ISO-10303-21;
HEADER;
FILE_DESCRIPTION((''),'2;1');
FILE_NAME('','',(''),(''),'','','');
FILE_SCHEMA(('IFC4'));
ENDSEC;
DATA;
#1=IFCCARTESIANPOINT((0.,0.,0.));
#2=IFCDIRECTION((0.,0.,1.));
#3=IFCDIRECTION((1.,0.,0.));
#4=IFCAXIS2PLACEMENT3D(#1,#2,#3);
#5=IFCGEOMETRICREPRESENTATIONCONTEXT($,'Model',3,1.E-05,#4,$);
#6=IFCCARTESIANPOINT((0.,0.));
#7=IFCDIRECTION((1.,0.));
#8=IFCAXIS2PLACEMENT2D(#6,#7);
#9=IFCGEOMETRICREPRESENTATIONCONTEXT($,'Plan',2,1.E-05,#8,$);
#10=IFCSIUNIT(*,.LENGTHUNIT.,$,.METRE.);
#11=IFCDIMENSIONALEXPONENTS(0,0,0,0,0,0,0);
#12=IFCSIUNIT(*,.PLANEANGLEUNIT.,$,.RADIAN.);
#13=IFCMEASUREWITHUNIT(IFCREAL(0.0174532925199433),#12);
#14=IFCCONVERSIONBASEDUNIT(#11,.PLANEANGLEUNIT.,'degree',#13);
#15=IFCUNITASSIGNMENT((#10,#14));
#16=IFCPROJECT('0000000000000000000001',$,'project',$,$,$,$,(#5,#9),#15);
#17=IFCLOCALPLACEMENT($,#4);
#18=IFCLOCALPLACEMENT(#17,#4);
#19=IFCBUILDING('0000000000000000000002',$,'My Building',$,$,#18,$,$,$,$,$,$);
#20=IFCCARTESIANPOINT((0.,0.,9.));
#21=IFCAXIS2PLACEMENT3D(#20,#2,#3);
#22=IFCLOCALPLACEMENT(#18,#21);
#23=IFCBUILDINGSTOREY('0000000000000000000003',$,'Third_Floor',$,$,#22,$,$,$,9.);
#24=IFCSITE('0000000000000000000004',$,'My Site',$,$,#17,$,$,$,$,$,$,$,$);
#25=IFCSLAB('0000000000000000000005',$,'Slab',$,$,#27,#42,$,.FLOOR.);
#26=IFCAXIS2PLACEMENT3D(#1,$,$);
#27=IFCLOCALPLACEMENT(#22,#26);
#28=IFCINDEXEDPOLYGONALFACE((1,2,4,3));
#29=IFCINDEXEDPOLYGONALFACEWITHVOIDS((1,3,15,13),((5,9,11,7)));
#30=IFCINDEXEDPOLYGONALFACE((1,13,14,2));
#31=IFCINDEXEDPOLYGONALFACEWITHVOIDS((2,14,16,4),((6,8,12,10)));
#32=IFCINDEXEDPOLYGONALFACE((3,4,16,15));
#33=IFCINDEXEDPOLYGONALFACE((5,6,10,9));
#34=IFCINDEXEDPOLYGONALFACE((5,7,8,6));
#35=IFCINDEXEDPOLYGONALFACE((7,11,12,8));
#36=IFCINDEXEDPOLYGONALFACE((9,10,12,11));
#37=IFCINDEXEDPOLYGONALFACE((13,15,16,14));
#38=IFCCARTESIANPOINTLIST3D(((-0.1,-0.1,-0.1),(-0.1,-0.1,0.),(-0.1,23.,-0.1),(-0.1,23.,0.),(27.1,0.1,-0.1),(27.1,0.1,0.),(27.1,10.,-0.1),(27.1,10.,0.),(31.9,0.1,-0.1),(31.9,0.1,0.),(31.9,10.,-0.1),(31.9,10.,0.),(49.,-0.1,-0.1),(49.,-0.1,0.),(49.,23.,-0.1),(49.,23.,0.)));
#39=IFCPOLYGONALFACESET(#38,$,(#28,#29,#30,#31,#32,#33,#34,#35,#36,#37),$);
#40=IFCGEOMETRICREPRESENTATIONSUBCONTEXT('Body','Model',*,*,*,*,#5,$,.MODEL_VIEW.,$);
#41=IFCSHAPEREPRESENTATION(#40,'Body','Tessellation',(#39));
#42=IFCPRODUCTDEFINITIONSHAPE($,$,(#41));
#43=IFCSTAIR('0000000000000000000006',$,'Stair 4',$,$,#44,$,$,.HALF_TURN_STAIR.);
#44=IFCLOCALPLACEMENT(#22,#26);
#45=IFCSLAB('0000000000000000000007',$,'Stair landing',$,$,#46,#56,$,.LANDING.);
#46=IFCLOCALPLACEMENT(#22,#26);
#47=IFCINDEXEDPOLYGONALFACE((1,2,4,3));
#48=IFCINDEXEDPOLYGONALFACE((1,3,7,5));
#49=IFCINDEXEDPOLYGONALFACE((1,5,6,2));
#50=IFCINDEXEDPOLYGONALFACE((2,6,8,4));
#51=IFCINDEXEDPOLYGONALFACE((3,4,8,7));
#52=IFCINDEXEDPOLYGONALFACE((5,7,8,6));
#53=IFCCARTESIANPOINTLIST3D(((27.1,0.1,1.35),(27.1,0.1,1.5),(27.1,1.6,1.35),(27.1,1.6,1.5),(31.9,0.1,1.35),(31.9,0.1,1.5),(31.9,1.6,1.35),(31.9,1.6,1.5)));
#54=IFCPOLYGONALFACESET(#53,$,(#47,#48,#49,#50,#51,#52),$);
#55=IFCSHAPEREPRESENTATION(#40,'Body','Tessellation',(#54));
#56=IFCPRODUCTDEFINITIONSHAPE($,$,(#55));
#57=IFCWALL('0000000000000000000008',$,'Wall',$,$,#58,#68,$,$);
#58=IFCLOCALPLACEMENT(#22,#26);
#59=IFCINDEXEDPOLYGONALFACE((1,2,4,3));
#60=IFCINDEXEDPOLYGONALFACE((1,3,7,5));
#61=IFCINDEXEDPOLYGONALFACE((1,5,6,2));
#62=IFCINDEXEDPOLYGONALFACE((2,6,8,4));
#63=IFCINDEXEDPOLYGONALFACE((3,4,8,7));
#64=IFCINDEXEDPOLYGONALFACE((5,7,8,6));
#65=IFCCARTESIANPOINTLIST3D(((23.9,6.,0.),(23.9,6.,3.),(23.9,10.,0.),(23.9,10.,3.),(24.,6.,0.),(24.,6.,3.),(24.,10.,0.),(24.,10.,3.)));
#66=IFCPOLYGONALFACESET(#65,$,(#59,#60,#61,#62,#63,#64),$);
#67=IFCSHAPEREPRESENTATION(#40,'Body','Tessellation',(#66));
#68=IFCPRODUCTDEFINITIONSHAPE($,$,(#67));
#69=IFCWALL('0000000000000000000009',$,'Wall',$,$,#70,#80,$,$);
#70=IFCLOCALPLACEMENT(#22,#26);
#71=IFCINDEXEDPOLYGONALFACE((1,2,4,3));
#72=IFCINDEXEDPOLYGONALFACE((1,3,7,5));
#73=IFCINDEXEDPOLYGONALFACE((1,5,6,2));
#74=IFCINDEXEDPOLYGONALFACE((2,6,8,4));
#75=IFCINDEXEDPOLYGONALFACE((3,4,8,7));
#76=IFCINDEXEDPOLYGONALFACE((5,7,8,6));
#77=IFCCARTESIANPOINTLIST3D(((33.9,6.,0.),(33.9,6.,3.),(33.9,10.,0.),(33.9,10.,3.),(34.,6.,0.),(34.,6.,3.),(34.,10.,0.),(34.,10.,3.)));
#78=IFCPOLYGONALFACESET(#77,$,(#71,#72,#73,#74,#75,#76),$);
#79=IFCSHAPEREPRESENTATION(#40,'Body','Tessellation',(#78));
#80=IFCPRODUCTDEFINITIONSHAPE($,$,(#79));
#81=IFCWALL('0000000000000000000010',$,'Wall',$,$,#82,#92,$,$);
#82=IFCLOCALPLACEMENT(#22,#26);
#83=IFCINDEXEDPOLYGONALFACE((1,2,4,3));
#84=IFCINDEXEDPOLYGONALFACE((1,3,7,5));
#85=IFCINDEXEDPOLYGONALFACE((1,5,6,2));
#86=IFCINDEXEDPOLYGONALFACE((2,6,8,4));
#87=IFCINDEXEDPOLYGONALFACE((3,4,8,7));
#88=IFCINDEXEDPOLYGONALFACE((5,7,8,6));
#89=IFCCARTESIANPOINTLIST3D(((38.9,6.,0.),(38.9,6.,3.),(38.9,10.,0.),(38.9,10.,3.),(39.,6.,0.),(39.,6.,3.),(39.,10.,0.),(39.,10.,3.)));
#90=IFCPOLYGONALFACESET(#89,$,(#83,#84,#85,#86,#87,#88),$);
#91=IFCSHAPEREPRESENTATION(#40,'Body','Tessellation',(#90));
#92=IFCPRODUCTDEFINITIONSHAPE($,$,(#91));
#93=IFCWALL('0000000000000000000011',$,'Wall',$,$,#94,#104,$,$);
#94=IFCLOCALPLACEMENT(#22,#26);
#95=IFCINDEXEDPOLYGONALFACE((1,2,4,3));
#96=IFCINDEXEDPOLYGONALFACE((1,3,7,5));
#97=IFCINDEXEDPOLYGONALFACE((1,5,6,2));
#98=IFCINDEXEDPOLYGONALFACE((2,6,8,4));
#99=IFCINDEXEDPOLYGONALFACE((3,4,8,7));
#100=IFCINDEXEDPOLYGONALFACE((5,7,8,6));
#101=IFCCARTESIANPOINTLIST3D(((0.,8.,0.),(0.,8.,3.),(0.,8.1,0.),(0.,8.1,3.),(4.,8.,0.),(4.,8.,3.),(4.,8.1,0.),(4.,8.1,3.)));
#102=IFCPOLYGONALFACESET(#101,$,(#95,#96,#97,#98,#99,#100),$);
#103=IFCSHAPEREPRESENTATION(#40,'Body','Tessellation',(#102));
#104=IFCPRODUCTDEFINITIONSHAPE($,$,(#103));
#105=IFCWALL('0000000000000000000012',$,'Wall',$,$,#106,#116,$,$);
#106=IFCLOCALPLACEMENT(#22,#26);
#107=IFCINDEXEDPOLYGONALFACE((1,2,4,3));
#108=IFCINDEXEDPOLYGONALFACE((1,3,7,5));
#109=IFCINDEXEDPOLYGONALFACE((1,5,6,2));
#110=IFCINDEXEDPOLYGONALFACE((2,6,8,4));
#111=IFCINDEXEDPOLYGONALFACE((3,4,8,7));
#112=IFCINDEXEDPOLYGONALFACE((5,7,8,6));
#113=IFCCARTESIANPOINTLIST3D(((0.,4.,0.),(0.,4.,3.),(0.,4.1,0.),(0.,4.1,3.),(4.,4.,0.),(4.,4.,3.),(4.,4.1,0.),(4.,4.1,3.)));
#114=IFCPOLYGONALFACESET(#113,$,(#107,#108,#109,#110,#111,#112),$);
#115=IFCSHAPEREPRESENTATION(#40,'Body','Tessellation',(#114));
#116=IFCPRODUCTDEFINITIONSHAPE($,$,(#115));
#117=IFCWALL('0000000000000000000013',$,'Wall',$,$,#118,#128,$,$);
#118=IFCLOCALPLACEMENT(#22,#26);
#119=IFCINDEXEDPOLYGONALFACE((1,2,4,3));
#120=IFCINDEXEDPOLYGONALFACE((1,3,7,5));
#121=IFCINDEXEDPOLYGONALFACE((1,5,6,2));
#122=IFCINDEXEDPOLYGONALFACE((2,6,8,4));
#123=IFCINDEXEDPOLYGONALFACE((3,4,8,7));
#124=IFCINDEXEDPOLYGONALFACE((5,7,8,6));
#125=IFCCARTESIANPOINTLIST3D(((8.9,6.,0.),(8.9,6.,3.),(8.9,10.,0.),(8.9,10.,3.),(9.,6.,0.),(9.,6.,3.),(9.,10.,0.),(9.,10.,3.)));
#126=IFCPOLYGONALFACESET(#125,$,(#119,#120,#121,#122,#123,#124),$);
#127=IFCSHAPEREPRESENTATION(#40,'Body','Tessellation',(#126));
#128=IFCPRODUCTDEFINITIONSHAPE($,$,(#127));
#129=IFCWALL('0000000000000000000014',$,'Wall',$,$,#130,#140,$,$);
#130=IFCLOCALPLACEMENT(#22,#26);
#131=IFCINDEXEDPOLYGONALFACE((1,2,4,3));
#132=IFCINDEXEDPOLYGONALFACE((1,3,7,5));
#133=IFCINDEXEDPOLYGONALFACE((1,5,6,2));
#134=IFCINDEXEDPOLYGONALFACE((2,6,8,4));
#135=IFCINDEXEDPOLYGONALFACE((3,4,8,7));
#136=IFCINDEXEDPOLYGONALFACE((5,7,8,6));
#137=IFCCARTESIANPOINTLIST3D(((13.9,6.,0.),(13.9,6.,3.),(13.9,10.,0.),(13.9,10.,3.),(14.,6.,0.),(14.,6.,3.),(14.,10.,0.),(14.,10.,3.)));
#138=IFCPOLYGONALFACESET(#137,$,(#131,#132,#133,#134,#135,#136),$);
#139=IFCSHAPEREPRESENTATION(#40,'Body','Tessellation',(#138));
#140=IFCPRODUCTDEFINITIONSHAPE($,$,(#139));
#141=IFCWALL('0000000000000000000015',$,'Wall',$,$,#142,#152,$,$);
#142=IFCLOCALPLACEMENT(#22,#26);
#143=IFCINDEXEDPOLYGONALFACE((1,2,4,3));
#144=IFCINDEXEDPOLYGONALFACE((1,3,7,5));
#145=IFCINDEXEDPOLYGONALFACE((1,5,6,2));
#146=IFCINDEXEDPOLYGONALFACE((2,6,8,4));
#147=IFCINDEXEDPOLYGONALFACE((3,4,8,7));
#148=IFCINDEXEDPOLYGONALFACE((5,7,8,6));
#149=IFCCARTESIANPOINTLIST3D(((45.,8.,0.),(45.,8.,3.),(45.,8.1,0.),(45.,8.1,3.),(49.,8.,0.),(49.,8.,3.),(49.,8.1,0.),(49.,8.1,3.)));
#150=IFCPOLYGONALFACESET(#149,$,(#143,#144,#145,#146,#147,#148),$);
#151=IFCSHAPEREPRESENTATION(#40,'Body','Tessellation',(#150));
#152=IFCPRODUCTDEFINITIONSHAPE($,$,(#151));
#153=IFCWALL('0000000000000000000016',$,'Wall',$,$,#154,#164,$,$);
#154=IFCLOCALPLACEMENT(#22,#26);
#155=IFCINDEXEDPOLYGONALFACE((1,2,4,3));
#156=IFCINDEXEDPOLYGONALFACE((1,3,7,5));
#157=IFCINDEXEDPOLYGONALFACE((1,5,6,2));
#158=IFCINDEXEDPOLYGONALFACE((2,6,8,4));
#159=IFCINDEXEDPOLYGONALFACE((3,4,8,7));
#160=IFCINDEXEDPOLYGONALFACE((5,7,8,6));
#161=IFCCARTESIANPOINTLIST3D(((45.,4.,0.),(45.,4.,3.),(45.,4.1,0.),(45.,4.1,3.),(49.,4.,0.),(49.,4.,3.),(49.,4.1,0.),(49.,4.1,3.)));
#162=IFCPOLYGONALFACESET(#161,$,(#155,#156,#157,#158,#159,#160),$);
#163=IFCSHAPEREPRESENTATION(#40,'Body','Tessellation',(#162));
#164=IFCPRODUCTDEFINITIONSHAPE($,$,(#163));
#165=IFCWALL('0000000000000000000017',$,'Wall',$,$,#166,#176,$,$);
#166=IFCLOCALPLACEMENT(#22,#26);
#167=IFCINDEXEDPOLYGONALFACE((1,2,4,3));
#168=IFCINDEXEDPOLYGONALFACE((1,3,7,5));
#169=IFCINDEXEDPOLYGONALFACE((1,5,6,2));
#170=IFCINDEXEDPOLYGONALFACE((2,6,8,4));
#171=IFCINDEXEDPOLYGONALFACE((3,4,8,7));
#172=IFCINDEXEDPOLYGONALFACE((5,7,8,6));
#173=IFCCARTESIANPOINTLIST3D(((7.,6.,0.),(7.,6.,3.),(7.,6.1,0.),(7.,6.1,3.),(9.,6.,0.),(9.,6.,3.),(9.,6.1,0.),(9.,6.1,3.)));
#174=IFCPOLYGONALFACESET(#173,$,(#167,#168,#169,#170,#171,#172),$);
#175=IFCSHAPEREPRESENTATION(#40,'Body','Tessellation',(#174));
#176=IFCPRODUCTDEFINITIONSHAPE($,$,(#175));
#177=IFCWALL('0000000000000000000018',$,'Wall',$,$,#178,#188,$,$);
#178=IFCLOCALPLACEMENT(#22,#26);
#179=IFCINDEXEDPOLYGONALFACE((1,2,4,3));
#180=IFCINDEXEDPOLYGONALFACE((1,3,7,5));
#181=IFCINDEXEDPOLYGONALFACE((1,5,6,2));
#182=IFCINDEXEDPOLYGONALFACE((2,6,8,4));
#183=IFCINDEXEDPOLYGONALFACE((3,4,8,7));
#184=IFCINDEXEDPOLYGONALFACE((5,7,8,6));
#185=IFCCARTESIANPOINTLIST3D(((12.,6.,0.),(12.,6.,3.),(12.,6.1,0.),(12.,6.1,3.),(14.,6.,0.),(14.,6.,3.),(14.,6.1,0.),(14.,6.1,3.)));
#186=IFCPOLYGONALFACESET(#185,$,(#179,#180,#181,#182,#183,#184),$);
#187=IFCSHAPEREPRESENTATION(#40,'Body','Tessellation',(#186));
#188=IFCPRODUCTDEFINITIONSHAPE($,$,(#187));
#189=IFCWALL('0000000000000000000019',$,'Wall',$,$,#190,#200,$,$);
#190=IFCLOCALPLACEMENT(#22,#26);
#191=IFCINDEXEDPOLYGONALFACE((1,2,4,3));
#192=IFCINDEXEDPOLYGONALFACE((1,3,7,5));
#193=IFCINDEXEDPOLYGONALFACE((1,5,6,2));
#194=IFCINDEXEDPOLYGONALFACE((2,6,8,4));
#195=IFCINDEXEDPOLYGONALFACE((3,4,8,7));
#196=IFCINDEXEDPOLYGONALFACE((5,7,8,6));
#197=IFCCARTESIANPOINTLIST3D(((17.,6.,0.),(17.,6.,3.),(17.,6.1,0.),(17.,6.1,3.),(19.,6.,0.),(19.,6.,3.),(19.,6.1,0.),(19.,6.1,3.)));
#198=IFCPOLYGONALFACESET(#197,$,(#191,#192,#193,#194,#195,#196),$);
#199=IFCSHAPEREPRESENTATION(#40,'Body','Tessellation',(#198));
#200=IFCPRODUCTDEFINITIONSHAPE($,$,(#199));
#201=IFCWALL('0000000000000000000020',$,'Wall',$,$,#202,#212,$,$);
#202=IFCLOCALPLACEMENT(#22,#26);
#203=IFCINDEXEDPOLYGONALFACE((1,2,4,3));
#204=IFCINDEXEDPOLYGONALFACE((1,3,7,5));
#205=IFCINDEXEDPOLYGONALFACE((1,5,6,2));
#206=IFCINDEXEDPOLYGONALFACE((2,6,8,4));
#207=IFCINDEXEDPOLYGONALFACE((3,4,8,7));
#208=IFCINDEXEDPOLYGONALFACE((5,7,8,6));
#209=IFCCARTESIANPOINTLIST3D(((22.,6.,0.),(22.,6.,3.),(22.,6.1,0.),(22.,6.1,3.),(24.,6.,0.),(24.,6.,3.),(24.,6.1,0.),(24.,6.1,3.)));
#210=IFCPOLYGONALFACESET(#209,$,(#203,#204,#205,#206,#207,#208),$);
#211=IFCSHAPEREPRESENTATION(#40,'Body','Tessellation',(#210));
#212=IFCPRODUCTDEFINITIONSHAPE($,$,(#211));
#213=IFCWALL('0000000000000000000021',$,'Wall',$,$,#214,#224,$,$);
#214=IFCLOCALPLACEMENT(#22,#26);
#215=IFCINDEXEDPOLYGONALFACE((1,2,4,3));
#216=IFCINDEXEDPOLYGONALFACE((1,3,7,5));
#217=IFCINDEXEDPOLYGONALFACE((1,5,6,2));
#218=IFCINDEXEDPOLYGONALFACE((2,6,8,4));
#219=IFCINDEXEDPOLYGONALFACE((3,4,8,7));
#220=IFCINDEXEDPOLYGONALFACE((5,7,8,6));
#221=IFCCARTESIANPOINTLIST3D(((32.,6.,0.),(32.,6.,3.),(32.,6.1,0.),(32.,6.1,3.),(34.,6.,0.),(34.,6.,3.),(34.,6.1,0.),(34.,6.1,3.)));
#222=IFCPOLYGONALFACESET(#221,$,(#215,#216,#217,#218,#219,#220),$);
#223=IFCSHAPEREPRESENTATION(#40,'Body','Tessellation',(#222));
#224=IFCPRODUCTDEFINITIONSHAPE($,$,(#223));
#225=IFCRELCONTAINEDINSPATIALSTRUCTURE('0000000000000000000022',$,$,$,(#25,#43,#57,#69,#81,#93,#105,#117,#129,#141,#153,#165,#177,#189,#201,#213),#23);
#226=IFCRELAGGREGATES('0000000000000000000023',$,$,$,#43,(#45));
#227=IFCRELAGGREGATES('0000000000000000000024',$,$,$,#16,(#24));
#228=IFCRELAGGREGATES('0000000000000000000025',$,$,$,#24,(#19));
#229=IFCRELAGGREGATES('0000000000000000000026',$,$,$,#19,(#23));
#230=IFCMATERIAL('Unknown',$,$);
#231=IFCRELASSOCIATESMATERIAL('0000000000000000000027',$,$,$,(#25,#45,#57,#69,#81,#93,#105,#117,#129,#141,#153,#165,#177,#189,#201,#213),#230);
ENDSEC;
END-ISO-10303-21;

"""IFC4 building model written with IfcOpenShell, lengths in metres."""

from ifc_helpers import new_model, entity, si_unit, converted_unit, frame, frame_2d, origin, origin_with_axes, origin_2d_with_axis, place, context, subcontext, project, spatial, rectangle, extrude, material, element, aggregate, save


model = new_model("IFC4")

# Units and contexts
model_context = context("Model", 3, precision=1e-05, world=origin_with_axes())
plan_context = context("Plan", 2, precision=1e-05, world=origin_2d_with_axis())
body_context = subcontext(model_context, "Body", "Model", "MODEL_VIEW")
ifc_project = project(units=[si_unit("LENGTHUNIT", "METRE"), converted_unit("PLANEANGLEUNIT", "degree", entity("IfcReal", 0.0174532925199433), si_unit("PLANEANGLEUNIT", "RADIAN"), dimensions=[0, 0, 0, 0, 0, 0, 0])], contexts=[model_context, plan_context])

# Site, building, storey
site_placement = place(None, origin_with_axes())
site = spatial("IfcSite", under=ifc_project, at=site_placement, Name="My Site")
building_placement = place(site_placement, origin_with_axes())
building = spatial("IfcBuilding", under=site, at=building_placement, Name="My Building")
storey_placement = place(building_placement, frame((0.0, 0.0, 9.0), z_axis=(0.0, 0.0, 1.0), x_axis=(1.0, 0.0, 0.0)))
storey = spatial("IfcBuildingStorey", under=building, at=storey_placement, Name="Third_Floor", Elevation=9.0)

# Slab, opening
ifc_material = material(Name="Unknown")
slab_1_placement = place(storey_placement, origin_with_axes())
slab_1 = element("IfcSlab", 1, at=slab_1_placement, inside=storey, material=ifc_material, Name="Slab", PredefinedType="FLOOR", context=body_context, shape_type="SweptSolid", body=[
    extrude(rectangle(XDim=49.1, YDim=23.1, at=frame_2d((24.45, 11.45))), frame((0.0, 0.0, -0.1)), (0.0, 0.0, 1.0), 0.1),
])
opening_placement = place(slab_1_placement, origin_with_axes())
element("IfcOpeningElement", 2, at=opening_placement, cuts=slab_1, context=body_context, shape_type="SweptSolid", body=[
    extrude(rectangle(XDim=4.8, YDim=9.9, at=frame_2d((29.5, 5.05))), frame((0.0, 0.0, -0.25)), (0.0, 0.0, 1.0), 0.4),
])

# Stair, slab
stair_placement = place(storey_placement, origin_with_axes())
stair = element("IfcStair", 3, at=stair_placement, inside=storey, Name="Stair 4", PredefinedType="HALF_TURN_STAIR")
slab_2_placement = place(stair_placement, origin_with_axes())
slab_2 = element("IfcSlab", 4, at=slab_2_placement, material=ifc_material, Name="Stair landing", PredefinedType="LANDING", context=body_context, shape_type="SweptSolid", body=[
    extrude(rectangle(XDim=4.8, YDim=1.5, at=frame_2d((29.5, 0.85))), frame((0.0, 0.0, 1.35)), (0.0, 0.0, 1.0), 0.15),
])

# Walls
wall_1_placement = place(storey_placement, origin_with_axes())
element("IfcWall", 5, at=wall_1_placement, inside=storey, material=ifc_material, Name="Wall", context=body_context, shape_type="SweptSolid", body=[
    extrude(rectangle(XDim=0.1, YDim=4.0, at=frame_2d((23.95, 8.0))), origin(), (0.0, 0.0, 1.0), 3.0),
])
wall_2_placement = place(storey_placement, origin_with_axes())
element("IfcWall", 6, at=wall_2_placement, inside=storey, material=ifc_material, Name="Wall", context=body_context, shape_type="SweptSolid", body=[
    extrude(rectangle(XDim=0.1, YDim=4.0, at=frame_2d((33.95, 8.0))), origin(), (0.0, 0.0, 1.0), 3.0),
])
wall_3_placement = place(storey_placement, origin_with_axes())
element("IfcWall", 7, at=wall_3_placement, inside=storey, material=ifc_material, Name="Wall", context=body_context, shape_type="SweptSolid", body=[
    extrude(rectangle(XDim=0.1, YDim=4.0, at=frame_2d((38.95, 8.0))), origin(), (0.0, 0.0, 1.0), 3.0),
])
wall_4_placement = place(storey_placement, origin_with_axes())
element("IfcWall", 8, at=wall_4_placement, inside=storey, material=ifc_material, Name="Wall", context=body_context, shape_type="SweptSolid", body=[
    extrude(rectangle(XDim=4.0, YDim=0.1, at=frame_2d((2.0, 8.05))), origin(), (0.0, 0.0, 1.0), 3.0),
])
wall_5_placement = place(storey_placement, origin_with_axes())
element("IfcWall", 9, at=wall_5_placement, inside=storey, material=ifc_material, Name="Wall", context=body_context, shape_type="SweptSolid", body=[
    extrude(rectangle(XDim=4.0, YDim=0.1, at=frame_2d((2.0, 4.05))), origin(), (0.0, 0.0, 1.0), 3.0),
])
wall_6_placement = place(storey_placement, origin_with_axes())
element("IfcWall", 10, at=wall_6_placement, inside=storey, material=ifc_material, Name="Wall", context=body_context, shape_type="SweptSolid", body=[
    extrude(rectangle(XDim=0.1, YDim=4.0, at=frame_2d((8.95, 8.0))), origin(), (0.0, 0.0, 1.0), 3.0),
])
wall_7_placement = place(storey_placement, origin_with_axes())
element("IfcWall", 11, at=wall_7_placement, inside=storey, material=ifc_material, Name="Wall", context=body_context, shape_type="SweptSolid", body=[
    extrude(rectangle(XDim=0.1, YDim=4.0, at=frame_2d((13.95, 8.0))), origin(), (0.0, 0.0, 1.0), 3.0),
])
wall_8_placement = place(storey_placement, origin_with_axes())
element("IfcWall", 12, at=wall_8_placement, inside=storey, material=ifc_material, Name="Wall", context=body_context, shape_type="SweptSolid", body=[
    extrude(rectangle(XDim=4.0, YDim=0.1, at=frame_2d((47.0, 8.05))), origin(), (0.0, 0.0, 1.0), 3.0),
])
wall_9_placement = place(storey_placement, origin_with_axes())
element("IfcWall", 13, at=wall_9_placement, inside=storey, material=ifc_material, Name="Wall", context=body_context, shape_type="SweptSolid", body=[
    extrude(rectangle(XDim=4.0, YDim=0.1, at=frame_2d((47.0, 4.05))), origin(), (0.0, 0.0, 1.0), 3.0),
])
wall_10_placement = place(storey_placement, origin_with_axes())
element("IfcWall", 14, at=wall_10_placement, inside=storey, material=ifc_material, Name="Wall", context=body_context, shape_type="SweptSolid", body=[
    extrude(rectangle(XDim=2.0, YDim=0.1, at=frame_2d((8.0, 6.05))), origin(), (0.0, 0.0, 1.0), 3.0),
])
wall_11_placement = place(storey_placement, origin_with_axes())
element("IfcWall", 15, at=wall_11_placement, inside=storey, material=ifc_material, Name="Wall", context=body_context, shape_type="SweptSolid", body=[
    extrude(rectangle(XDim=2.0, YDim=0.1, at=frame_2d((13.0, 6.05))), origin(), (0.0, 0.0, 1.0), 3.0),
])
wall_12_placement = place(storey_placement, origin_with_axes())
element("IfcWall", 16, at=wall_12_placement, inside=storey, material=ifc_material, Name="Wall", context=body_context, shape_type="SweptSolid", body=[
    extrude(rectangle(XDim=2.0, YDim=0.1, at=frame_2d((18.0, 6.05))), origin(), (0.0, 0.0, 1.0), 3.0),
])
wall_13_placement = place(storey_placement, origin_with_axes())
element("IfcWall", 17, at=wall_13_placement, inside=storey, material=ifc_material, Name="Wall", context=body_context, shape_type="SweptSolid", body=[
    extrude(rectangle(XDim=2.0, YDim=0.1, at=frame_2d((23.0, 6.05))), origin(), (0.0, 0.0, 1.0), 3.0),
])
wall_14_placement = place(storey_placement, origin_with_axes())
element("IfcWall", 18, at=wall_14_placement, inside=storey, material=ifc_material, Name="Wall", context=body_context, shape_type="SweptSolid", body=[
    extrude(rectangle(XDim=2.0, YDim=0.1, at=frame_2d((33.0, 6.05))), origin(), (0.0, 0.0, 1.0), 3.0),
])

aggregate(stair, [slab_2])

save(model, "model.ifc")
